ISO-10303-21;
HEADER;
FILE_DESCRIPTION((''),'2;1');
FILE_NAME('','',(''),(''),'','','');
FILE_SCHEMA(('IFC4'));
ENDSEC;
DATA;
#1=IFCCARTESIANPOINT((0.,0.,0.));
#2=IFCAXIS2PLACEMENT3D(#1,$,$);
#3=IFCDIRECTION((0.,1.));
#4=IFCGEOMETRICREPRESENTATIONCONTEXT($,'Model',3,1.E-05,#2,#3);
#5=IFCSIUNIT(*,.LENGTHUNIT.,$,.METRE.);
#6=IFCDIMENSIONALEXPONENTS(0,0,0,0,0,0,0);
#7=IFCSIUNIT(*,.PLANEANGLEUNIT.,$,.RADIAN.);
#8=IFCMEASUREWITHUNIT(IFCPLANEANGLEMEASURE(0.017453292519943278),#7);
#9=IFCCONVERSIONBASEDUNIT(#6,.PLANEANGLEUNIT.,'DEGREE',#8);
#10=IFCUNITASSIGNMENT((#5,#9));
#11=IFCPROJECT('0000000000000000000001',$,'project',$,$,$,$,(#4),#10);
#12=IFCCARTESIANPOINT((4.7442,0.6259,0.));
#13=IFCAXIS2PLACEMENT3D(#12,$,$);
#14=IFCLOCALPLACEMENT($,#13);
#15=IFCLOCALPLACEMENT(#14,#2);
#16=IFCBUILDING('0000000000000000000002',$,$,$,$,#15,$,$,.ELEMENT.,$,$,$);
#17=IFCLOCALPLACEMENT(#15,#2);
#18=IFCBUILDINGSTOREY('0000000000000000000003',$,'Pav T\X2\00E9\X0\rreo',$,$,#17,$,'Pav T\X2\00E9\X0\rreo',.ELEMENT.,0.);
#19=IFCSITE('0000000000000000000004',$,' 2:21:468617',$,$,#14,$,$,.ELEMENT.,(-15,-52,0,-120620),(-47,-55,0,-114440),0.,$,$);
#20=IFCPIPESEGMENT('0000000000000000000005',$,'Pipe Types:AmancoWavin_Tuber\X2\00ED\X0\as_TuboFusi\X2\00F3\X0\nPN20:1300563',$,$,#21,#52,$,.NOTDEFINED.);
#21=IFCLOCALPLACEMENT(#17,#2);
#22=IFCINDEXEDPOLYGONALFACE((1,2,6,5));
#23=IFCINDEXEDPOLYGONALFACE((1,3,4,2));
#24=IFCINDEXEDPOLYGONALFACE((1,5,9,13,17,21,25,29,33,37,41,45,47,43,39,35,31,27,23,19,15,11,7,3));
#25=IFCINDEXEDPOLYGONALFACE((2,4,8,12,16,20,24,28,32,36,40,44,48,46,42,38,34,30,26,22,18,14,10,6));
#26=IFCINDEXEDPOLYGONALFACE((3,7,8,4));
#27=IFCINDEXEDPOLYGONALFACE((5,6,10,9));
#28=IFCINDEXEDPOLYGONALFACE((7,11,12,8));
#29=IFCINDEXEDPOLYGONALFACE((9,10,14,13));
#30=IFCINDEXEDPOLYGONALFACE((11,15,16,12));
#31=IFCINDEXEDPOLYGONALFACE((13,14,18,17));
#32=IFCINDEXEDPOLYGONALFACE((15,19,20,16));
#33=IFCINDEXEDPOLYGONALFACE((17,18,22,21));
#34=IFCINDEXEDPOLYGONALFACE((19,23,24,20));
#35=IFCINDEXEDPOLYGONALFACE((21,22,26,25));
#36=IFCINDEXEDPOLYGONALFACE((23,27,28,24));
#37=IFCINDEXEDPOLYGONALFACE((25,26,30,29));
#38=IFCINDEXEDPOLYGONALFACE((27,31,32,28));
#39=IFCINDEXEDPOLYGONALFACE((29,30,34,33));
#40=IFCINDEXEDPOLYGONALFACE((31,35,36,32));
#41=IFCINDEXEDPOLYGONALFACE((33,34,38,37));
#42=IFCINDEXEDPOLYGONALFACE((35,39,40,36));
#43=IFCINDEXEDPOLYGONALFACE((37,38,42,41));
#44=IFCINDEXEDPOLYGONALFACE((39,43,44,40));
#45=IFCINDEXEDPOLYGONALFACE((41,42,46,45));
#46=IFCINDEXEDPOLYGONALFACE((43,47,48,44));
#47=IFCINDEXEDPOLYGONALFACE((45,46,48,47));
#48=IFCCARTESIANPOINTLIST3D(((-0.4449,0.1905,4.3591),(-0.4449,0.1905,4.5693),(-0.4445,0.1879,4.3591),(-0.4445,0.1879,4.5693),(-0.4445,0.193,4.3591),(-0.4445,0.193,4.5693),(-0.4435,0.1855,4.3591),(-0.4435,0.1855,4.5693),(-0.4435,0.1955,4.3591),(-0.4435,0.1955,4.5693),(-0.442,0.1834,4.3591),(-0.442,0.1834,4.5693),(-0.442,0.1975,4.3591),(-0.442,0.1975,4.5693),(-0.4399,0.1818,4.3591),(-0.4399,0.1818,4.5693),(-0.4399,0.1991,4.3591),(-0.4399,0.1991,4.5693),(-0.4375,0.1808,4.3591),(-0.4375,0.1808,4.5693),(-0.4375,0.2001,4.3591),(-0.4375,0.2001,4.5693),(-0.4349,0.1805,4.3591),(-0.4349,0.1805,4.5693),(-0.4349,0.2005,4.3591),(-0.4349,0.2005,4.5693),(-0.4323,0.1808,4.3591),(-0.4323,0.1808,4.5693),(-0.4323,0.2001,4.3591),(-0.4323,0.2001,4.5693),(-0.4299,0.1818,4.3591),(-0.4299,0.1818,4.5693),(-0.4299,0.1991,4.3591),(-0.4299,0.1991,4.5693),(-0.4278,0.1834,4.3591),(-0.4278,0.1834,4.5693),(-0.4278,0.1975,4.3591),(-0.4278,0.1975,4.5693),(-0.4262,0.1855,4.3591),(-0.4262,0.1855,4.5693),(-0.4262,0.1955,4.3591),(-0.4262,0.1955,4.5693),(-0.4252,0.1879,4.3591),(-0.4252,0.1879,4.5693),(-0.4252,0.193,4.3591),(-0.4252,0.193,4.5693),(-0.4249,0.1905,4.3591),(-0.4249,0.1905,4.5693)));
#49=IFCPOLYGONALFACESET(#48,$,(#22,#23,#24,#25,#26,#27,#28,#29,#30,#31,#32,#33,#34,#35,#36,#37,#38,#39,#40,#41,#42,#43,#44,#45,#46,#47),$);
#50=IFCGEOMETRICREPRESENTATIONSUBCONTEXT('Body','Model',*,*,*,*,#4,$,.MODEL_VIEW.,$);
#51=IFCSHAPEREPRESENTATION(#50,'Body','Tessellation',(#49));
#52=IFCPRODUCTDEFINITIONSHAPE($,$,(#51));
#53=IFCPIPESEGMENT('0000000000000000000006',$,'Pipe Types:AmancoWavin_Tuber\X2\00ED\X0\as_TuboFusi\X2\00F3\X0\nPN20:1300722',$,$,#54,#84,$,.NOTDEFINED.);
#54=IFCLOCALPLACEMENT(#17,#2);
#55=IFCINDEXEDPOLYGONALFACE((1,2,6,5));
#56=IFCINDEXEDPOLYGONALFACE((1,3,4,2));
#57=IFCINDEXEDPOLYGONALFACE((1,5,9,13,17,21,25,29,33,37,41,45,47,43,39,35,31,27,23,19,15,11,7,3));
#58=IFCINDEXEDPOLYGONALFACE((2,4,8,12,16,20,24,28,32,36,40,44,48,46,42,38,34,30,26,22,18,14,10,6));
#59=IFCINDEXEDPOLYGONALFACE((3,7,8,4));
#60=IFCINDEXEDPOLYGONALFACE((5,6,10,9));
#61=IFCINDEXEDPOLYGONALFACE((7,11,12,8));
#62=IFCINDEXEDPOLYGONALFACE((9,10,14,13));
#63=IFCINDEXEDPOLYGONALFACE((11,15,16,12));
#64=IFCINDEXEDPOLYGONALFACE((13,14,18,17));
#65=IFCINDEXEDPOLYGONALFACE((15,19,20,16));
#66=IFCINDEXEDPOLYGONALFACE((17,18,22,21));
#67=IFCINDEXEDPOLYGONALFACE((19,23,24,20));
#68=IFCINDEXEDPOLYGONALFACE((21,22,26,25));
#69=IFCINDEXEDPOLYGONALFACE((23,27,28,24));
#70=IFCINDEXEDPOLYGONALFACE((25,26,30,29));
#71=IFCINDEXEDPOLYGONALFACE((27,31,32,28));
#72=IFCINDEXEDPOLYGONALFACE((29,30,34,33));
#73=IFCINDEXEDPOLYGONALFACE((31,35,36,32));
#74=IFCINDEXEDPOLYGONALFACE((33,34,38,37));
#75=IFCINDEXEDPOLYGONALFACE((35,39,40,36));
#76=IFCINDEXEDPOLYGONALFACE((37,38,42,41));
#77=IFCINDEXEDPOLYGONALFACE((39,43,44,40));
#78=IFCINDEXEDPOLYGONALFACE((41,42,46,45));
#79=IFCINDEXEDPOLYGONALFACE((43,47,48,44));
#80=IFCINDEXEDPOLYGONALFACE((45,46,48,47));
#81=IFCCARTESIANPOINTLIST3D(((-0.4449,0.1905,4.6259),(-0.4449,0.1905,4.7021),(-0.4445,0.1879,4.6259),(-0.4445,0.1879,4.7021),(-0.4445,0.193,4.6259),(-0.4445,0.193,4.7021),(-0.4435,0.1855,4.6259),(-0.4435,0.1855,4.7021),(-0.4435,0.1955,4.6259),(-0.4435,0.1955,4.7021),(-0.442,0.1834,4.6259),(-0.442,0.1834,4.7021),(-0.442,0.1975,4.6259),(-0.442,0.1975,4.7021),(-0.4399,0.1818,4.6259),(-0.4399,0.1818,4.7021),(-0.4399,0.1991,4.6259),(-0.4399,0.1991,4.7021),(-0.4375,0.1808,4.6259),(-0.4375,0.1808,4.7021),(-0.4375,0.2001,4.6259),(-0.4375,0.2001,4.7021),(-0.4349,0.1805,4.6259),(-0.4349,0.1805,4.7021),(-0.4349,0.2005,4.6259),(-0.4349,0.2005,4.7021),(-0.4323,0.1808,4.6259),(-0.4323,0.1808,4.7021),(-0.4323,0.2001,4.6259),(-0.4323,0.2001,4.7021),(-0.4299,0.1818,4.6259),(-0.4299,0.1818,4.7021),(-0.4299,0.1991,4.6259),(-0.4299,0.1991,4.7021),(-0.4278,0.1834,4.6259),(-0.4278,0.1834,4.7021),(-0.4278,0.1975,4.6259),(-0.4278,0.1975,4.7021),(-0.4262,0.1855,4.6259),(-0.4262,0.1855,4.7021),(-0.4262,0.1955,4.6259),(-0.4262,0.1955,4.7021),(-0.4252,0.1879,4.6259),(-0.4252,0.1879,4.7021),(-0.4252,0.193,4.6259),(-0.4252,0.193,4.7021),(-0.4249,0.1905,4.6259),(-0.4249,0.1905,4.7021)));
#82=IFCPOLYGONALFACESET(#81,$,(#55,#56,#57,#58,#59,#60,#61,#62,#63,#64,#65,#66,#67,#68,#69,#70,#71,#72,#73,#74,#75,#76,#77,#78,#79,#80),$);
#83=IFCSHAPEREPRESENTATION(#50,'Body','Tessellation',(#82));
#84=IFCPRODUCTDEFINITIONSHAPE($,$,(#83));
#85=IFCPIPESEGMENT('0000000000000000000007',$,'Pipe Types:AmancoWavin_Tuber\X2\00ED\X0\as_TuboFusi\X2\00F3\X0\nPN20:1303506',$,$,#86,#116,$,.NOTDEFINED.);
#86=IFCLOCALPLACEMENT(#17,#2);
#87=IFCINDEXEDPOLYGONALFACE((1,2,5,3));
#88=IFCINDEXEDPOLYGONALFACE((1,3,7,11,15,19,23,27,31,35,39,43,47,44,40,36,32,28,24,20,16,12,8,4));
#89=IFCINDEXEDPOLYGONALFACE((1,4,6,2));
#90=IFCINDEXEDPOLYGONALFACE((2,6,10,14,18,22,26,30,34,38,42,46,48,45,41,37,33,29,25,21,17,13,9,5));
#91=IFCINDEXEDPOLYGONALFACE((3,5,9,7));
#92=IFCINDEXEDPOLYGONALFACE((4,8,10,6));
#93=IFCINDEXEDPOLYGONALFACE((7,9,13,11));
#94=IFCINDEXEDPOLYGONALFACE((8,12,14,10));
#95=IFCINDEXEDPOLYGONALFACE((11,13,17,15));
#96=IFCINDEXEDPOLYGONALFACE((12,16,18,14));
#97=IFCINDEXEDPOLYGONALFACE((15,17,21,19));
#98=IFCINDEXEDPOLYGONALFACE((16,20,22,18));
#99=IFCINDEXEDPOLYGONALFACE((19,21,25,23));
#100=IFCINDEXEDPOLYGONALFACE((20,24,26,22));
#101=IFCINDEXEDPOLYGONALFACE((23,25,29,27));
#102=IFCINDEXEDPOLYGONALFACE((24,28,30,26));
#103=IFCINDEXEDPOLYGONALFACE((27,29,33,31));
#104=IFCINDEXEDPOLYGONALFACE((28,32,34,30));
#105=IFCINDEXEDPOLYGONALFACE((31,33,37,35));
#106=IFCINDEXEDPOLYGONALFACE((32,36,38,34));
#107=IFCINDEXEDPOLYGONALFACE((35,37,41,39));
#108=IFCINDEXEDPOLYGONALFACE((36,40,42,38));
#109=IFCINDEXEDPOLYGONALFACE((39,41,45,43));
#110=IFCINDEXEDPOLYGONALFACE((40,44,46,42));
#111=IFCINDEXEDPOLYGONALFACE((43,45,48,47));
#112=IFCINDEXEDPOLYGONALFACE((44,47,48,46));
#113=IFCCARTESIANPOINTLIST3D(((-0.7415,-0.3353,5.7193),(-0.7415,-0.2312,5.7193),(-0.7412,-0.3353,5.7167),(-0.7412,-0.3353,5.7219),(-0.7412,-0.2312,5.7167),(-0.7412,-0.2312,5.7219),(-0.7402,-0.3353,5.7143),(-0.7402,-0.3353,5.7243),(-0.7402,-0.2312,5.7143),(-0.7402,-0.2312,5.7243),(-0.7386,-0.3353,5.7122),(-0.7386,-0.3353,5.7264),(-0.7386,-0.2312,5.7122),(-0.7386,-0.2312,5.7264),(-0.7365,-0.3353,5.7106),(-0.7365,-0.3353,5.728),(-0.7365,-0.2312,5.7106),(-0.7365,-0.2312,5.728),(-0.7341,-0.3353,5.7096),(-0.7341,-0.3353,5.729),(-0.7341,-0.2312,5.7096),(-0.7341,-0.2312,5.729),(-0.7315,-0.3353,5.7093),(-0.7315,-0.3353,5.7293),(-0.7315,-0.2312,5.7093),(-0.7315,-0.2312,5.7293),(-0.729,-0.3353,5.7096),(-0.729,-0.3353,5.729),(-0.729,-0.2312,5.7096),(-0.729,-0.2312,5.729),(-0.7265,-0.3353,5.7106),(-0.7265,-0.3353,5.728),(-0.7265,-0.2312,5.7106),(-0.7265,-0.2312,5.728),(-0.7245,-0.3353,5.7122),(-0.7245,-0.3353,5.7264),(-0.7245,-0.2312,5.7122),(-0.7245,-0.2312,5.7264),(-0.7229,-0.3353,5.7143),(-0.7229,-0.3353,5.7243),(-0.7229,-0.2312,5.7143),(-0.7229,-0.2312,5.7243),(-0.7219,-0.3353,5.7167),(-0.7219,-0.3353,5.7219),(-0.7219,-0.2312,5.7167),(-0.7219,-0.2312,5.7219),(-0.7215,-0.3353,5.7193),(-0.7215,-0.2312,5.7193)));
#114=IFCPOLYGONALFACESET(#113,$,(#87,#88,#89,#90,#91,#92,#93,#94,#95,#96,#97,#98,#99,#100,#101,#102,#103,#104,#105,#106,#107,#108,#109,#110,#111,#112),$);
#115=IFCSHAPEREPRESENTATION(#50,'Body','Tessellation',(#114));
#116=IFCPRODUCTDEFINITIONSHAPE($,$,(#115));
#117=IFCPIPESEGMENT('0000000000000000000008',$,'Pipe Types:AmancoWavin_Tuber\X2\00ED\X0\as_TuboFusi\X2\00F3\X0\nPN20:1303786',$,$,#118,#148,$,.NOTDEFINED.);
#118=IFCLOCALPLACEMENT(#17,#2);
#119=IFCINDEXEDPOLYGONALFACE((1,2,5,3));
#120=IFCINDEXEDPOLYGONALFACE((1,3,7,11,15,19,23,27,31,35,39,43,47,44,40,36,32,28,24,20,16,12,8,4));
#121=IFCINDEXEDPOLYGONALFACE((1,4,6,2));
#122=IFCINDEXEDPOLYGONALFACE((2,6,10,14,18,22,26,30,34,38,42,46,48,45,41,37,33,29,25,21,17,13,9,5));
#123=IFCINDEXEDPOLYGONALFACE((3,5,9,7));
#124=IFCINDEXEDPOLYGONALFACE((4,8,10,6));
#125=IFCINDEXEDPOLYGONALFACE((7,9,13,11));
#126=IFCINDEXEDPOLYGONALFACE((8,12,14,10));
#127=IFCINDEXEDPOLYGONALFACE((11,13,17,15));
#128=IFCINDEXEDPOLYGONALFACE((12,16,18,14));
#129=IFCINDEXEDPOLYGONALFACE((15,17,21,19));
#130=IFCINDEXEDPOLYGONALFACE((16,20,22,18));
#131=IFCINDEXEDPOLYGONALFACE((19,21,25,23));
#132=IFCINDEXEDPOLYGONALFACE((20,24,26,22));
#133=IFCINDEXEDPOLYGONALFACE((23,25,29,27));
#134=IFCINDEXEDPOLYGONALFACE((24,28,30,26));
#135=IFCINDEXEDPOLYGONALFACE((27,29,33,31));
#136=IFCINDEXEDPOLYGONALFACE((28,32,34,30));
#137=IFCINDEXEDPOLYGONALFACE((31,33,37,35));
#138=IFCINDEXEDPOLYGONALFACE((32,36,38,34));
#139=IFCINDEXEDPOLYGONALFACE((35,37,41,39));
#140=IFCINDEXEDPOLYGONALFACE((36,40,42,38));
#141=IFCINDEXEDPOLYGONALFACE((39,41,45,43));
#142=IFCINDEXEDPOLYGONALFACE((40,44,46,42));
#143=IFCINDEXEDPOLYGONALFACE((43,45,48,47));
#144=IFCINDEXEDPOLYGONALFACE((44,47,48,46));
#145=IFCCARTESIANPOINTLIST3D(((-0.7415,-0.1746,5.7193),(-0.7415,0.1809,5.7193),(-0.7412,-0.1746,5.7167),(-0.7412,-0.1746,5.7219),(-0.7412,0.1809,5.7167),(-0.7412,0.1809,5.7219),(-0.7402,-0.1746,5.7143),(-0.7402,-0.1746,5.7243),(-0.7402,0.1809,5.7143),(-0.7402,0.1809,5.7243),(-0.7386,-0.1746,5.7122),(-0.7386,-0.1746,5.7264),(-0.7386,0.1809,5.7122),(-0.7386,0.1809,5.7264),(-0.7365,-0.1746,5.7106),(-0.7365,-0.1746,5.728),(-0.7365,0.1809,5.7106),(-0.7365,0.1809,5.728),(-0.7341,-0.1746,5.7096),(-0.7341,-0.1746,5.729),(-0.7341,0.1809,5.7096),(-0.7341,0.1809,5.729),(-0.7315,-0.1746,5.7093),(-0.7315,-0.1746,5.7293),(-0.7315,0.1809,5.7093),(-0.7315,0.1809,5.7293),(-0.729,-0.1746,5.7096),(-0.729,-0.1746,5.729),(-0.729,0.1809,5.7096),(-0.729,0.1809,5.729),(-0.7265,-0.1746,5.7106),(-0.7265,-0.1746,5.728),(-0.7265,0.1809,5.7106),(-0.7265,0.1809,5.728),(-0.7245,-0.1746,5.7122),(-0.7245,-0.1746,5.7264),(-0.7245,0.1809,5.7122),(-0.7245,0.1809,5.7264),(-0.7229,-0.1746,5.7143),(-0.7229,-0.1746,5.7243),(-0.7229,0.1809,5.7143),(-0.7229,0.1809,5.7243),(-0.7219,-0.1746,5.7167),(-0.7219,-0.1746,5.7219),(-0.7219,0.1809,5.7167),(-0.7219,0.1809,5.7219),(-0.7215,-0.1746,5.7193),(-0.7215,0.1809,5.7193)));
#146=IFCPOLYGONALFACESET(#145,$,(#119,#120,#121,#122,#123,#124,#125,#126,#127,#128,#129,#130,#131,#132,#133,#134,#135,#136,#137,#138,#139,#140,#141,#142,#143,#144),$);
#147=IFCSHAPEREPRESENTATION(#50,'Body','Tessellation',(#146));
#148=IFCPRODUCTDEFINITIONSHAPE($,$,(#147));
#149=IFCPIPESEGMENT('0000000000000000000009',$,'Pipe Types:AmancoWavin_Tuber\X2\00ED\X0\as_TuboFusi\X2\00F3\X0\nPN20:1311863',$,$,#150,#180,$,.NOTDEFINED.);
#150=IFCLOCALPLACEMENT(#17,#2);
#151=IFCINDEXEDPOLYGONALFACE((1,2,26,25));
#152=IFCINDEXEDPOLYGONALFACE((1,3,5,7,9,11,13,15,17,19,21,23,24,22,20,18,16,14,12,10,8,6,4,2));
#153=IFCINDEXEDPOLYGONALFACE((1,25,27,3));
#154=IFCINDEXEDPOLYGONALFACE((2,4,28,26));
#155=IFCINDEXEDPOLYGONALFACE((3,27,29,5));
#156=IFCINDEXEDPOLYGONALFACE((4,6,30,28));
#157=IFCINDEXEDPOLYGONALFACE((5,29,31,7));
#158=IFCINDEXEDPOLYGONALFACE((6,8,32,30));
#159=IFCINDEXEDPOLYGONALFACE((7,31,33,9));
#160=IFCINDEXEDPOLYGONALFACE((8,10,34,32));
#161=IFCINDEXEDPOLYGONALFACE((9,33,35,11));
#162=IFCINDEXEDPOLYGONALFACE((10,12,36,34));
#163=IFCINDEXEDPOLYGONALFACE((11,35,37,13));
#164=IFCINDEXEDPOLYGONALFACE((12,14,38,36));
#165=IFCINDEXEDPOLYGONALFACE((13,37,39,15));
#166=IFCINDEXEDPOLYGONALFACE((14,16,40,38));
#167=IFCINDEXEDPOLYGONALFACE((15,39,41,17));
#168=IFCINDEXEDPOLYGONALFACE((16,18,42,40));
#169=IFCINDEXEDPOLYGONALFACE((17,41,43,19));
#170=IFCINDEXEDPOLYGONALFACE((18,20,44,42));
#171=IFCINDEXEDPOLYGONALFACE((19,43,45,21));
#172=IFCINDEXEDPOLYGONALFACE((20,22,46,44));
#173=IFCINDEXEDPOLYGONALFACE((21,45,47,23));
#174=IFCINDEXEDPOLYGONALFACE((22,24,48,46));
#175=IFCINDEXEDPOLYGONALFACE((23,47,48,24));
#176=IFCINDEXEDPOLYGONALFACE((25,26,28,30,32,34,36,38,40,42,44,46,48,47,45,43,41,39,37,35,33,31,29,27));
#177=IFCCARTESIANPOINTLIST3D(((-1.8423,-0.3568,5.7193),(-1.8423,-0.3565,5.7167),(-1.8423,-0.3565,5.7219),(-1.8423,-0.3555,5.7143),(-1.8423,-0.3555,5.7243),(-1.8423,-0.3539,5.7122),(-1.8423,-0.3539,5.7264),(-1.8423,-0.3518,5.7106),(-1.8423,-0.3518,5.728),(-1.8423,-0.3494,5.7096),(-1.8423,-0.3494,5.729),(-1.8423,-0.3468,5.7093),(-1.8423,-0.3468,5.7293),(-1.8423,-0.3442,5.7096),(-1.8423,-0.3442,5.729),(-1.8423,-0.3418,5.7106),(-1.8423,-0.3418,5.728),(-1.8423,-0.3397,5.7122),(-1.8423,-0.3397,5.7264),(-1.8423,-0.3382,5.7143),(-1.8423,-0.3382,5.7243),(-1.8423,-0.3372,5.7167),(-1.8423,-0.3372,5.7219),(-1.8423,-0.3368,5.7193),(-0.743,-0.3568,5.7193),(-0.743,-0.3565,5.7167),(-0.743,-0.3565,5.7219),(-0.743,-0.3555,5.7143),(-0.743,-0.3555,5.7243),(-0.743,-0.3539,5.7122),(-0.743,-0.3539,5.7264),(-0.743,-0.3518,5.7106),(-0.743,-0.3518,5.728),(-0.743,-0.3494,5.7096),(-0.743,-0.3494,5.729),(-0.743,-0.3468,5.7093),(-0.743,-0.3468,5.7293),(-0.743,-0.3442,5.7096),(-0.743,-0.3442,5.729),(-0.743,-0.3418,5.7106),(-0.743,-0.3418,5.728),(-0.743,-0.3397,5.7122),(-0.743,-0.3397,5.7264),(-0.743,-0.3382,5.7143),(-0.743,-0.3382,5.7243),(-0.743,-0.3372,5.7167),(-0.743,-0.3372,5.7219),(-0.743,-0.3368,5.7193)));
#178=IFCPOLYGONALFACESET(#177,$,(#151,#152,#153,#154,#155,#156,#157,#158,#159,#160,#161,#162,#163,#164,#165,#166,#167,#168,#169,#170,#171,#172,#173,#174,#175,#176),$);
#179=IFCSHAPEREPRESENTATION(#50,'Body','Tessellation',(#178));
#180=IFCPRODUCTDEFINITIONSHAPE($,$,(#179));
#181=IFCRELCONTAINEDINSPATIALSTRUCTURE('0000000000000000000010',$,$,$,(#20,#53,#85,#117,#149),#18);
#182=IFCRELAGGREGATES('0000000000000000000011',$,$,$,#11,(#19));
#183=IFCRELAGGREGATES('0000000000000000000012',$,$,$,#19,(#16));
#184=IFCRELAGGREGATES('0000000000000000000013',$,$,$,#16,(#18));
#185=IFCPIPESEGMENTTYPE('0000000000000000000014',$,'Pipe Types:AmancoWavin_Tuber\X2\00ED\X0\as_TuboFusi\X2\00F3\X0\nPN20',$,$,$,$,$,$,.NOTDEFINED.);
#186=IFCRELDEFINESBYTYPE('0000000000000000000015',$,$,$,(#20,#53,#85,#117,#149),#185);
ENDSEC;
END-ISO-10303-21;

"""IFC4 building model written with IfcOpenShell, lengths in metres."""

from ifc_helpers import new_model, entity, si_unit, converted_unit, direction, frame, origin, place, context, subcontext, project, spatial, arc, indexed_curve, outline, extrude, type_object, element, save


model = new_model("IFC4")

# Units and contexts
model_context = context("Model", 3, precision=1e-05, world=origin(), true_north=direction((0.0, 1.0)))
body_context = subcontext(model_context, "Body", "Model", "MODEL_VIEW")
ifc_project = project(units=[si_unit("LENGTHUNIT", "METRE"), converted_unit("PLANEANGLEUNIT", "DEGREE", entity("IfcPlaneAngleMeasure", 0.017453292519943278), si_unit("PLANEANGLEUNIT", "RADIAN"), dimensions=[0, 0, 0, 0, 0, 0, 0])], contexts=[model_context])

# Site, building, storey
site_placement = place(None, frame((4.7442, 0.6259, 0.0)))
site = spatial("IfcSite", under=ifc_project, at=site_placement, Name=" 2:21:468617", CompositionType="ELEMENT", RefLatitude=(-15, -52, 0, -120620), RefLongitude=(-47, -55, 0, -114440), RefElevation=0.0)
building_placement = place(site_placement, origin())
building = spatial("IfcBuilding", under=site, at=building_placement, CompositionType="ELEMENT")
storey_placement = place(building_placement, origin())
storey = spatial("IfcBuildingStorey", under=building, at=storey_placement, Name="Pav Térreo", LongName="Pav Térreo", CompositionType="ELEMENT", Elevation=0.0)

# Pipe segments
pipe_segment_type_1 = type_object("IfcPipeSegmentType", Name="Pipe Types:AmancoWavin_Tuberías_TuboFusiónPN20", PredefinedType="NOTDEFINED")
pipe_segment_1_placement = place(storey_placement, origin())
element("IfcPipeSegment", 1, at=pipe_segment_1_placement, inside=storey, type_object=pipe_segment_type_1, Name="Pipe Types:AmancoWavin_Tuberías_TuboFusiónPN20:1300563", PredefinedType="NOTDEFINED", context=body_context, shape_type="SweptSolid", body=[
    extrude(outline(indexed_curve([(0.01, 0.0), (0.0071, 0.0071), (0.0, 0.01), (-0.0071, 0.0071), (-0.01, 0.0), (-0.0071, -0.0071), (0.0, -0.01), (0.0071, -0.0071)], segments=[arc(1, 2, 3), arc(3, 4, 5), arc(5, 6, 7), arc(7, 8, 1)], self_intersect=False)), frame((-0.4349, 0.1905, 4.3591)), (0.0, 0.0, 1.0), 0.2102),
])
pipe_segment_2_placement = place(storey_placement, origin())
element("IfcPipeSegment", 2, at=pipe_segment_2_placement, inside=storey, type_object=pipe_segment_type_1, Name="Pipe Types:AmancoWavin_Tuberías_TuboFusiónPN20:1300722", PredefinedType="NOTDEFINED", context=body_context, shape_type="SweptSolid", body=[
    extrude(outline(indexed_curve([(0.01, 0.0), (0.0071, 0.0071), (0.0, 0.01), (-0.0071, 0.0071), (-0.01, 0.0), (-0.0071, -0.0071), (0.0, -0.01), (0.0071, -0.0071)], segments=[arc(1, 2, 3), arc(3, 4, 5), arc(5, 6, 7), arc(7, 8, 1)], self_intersect=False)), frame((-0.4349, 0.1905, 4.6259)), (0.0, 0.0, 1.0), 0.0762),
])
pipe_segment_3_placement = place(storey_placement, origin())
element("IfcPipeSegment", 3, at=pipe_segment_3_placement, inside=storey, type_object=pipe_segment_type_1, Name="Pipe Types:AmancoWavin_Tuberías_TuboFusiónPN20:1303506", PredefinedType="NOTDEFINED", context=body_context, shape_type="SweptSolid", body=[
    extrude(outline(indexed_curve([(0.01, 0.0), (0.0071, 0.0071), (0.0, 0.01), (-0.0071, 0.0071), (-0.01, 0.0), (-0.0071, -0.0071), (0.0, -0.01), (0.0071, -0.0071)], segments=[arc(1, 2, 3), arc(3, 4, 5), arc(5, 6, 7), arc(7, 8, 1)], self_intersect=False)), frame((-0.7315, -0.3353, 5.7193), z_axis=(0.0, 1.0, 0.0), x_axis=(-1.0, 0.0, 0.0)), (0.0, 0.0, 1.0), 0.1041),
])
pipe_segment_4_placement = place(storey_placement, origin())
element("IfcPipeSegment", 4, at=pipe_segment_4_placement, inside=storey, type_object=pipe_segment_type_1, Name="Pipe Types:AmancoWavin_Tuberías_TuboFusiónPN20:1303786", PredefinedType="NOTDEFINED", context=body_context, shape_type="SweptSolid", body=[
    extrude(outline(indexed_curve([(0.01, 0.0), (0.0071, 0.0071), (0.0, 0.01), (-0.0071, 0.0071), (-0.01, 0.0), (-0.0071, -0.0071), (0.0, -0.01), (0.0071, -0.0071)], segments=[arc(1, 2, 3), arc(3, 4, 5), arc(5, 6, 7), arc(7, 8, 1)], self_intersect=False)), frame((-0.7315, -0.1746, 5.7193), z_axis=(0.0, 1.0, 0.0), x_axis=(-1.0, 0.0, 0.0)), (0.0, 0.0, 1.0), 0.3555),
])
pipe_segment_5_placement = place(storey_placement, origin())
element("IfcPipeSegment", 5, at=pipe_segment_5_placement, inside=storey, type_object=pipe_segment_type_1, Name="Pipe Types:AmancoWavin_Tuberías_TuboFusiónPN20:1311863", PredefinedType="NOTDEFINED", context=body_context, shape_type="SweptSolid", body=[
    extrude(outline(indexed_curve([(0.01, 0.0), (0.0071, 0.0071), (0.0, 0.01), (-0.0071, 0.0071), (-0.01, 0.0), (-0.0071, -0.0071), (0.0, -0.01), (0.0071, -0.0071)], segments=[arc(1, 2, 3), arc(3, 4, 5), arc(5, 6, 7), arc(7, 8, 1)], self_intersect=False)), frame((-1.8423, -0.3468, 5.7193), z_axis=(1.0, 0.0, 0.0), x_axis=(0.0, -1.0, 0.0)), (0.0, 0.0, 1.0), 1.0992),
])

save(model, "model.ifc")
